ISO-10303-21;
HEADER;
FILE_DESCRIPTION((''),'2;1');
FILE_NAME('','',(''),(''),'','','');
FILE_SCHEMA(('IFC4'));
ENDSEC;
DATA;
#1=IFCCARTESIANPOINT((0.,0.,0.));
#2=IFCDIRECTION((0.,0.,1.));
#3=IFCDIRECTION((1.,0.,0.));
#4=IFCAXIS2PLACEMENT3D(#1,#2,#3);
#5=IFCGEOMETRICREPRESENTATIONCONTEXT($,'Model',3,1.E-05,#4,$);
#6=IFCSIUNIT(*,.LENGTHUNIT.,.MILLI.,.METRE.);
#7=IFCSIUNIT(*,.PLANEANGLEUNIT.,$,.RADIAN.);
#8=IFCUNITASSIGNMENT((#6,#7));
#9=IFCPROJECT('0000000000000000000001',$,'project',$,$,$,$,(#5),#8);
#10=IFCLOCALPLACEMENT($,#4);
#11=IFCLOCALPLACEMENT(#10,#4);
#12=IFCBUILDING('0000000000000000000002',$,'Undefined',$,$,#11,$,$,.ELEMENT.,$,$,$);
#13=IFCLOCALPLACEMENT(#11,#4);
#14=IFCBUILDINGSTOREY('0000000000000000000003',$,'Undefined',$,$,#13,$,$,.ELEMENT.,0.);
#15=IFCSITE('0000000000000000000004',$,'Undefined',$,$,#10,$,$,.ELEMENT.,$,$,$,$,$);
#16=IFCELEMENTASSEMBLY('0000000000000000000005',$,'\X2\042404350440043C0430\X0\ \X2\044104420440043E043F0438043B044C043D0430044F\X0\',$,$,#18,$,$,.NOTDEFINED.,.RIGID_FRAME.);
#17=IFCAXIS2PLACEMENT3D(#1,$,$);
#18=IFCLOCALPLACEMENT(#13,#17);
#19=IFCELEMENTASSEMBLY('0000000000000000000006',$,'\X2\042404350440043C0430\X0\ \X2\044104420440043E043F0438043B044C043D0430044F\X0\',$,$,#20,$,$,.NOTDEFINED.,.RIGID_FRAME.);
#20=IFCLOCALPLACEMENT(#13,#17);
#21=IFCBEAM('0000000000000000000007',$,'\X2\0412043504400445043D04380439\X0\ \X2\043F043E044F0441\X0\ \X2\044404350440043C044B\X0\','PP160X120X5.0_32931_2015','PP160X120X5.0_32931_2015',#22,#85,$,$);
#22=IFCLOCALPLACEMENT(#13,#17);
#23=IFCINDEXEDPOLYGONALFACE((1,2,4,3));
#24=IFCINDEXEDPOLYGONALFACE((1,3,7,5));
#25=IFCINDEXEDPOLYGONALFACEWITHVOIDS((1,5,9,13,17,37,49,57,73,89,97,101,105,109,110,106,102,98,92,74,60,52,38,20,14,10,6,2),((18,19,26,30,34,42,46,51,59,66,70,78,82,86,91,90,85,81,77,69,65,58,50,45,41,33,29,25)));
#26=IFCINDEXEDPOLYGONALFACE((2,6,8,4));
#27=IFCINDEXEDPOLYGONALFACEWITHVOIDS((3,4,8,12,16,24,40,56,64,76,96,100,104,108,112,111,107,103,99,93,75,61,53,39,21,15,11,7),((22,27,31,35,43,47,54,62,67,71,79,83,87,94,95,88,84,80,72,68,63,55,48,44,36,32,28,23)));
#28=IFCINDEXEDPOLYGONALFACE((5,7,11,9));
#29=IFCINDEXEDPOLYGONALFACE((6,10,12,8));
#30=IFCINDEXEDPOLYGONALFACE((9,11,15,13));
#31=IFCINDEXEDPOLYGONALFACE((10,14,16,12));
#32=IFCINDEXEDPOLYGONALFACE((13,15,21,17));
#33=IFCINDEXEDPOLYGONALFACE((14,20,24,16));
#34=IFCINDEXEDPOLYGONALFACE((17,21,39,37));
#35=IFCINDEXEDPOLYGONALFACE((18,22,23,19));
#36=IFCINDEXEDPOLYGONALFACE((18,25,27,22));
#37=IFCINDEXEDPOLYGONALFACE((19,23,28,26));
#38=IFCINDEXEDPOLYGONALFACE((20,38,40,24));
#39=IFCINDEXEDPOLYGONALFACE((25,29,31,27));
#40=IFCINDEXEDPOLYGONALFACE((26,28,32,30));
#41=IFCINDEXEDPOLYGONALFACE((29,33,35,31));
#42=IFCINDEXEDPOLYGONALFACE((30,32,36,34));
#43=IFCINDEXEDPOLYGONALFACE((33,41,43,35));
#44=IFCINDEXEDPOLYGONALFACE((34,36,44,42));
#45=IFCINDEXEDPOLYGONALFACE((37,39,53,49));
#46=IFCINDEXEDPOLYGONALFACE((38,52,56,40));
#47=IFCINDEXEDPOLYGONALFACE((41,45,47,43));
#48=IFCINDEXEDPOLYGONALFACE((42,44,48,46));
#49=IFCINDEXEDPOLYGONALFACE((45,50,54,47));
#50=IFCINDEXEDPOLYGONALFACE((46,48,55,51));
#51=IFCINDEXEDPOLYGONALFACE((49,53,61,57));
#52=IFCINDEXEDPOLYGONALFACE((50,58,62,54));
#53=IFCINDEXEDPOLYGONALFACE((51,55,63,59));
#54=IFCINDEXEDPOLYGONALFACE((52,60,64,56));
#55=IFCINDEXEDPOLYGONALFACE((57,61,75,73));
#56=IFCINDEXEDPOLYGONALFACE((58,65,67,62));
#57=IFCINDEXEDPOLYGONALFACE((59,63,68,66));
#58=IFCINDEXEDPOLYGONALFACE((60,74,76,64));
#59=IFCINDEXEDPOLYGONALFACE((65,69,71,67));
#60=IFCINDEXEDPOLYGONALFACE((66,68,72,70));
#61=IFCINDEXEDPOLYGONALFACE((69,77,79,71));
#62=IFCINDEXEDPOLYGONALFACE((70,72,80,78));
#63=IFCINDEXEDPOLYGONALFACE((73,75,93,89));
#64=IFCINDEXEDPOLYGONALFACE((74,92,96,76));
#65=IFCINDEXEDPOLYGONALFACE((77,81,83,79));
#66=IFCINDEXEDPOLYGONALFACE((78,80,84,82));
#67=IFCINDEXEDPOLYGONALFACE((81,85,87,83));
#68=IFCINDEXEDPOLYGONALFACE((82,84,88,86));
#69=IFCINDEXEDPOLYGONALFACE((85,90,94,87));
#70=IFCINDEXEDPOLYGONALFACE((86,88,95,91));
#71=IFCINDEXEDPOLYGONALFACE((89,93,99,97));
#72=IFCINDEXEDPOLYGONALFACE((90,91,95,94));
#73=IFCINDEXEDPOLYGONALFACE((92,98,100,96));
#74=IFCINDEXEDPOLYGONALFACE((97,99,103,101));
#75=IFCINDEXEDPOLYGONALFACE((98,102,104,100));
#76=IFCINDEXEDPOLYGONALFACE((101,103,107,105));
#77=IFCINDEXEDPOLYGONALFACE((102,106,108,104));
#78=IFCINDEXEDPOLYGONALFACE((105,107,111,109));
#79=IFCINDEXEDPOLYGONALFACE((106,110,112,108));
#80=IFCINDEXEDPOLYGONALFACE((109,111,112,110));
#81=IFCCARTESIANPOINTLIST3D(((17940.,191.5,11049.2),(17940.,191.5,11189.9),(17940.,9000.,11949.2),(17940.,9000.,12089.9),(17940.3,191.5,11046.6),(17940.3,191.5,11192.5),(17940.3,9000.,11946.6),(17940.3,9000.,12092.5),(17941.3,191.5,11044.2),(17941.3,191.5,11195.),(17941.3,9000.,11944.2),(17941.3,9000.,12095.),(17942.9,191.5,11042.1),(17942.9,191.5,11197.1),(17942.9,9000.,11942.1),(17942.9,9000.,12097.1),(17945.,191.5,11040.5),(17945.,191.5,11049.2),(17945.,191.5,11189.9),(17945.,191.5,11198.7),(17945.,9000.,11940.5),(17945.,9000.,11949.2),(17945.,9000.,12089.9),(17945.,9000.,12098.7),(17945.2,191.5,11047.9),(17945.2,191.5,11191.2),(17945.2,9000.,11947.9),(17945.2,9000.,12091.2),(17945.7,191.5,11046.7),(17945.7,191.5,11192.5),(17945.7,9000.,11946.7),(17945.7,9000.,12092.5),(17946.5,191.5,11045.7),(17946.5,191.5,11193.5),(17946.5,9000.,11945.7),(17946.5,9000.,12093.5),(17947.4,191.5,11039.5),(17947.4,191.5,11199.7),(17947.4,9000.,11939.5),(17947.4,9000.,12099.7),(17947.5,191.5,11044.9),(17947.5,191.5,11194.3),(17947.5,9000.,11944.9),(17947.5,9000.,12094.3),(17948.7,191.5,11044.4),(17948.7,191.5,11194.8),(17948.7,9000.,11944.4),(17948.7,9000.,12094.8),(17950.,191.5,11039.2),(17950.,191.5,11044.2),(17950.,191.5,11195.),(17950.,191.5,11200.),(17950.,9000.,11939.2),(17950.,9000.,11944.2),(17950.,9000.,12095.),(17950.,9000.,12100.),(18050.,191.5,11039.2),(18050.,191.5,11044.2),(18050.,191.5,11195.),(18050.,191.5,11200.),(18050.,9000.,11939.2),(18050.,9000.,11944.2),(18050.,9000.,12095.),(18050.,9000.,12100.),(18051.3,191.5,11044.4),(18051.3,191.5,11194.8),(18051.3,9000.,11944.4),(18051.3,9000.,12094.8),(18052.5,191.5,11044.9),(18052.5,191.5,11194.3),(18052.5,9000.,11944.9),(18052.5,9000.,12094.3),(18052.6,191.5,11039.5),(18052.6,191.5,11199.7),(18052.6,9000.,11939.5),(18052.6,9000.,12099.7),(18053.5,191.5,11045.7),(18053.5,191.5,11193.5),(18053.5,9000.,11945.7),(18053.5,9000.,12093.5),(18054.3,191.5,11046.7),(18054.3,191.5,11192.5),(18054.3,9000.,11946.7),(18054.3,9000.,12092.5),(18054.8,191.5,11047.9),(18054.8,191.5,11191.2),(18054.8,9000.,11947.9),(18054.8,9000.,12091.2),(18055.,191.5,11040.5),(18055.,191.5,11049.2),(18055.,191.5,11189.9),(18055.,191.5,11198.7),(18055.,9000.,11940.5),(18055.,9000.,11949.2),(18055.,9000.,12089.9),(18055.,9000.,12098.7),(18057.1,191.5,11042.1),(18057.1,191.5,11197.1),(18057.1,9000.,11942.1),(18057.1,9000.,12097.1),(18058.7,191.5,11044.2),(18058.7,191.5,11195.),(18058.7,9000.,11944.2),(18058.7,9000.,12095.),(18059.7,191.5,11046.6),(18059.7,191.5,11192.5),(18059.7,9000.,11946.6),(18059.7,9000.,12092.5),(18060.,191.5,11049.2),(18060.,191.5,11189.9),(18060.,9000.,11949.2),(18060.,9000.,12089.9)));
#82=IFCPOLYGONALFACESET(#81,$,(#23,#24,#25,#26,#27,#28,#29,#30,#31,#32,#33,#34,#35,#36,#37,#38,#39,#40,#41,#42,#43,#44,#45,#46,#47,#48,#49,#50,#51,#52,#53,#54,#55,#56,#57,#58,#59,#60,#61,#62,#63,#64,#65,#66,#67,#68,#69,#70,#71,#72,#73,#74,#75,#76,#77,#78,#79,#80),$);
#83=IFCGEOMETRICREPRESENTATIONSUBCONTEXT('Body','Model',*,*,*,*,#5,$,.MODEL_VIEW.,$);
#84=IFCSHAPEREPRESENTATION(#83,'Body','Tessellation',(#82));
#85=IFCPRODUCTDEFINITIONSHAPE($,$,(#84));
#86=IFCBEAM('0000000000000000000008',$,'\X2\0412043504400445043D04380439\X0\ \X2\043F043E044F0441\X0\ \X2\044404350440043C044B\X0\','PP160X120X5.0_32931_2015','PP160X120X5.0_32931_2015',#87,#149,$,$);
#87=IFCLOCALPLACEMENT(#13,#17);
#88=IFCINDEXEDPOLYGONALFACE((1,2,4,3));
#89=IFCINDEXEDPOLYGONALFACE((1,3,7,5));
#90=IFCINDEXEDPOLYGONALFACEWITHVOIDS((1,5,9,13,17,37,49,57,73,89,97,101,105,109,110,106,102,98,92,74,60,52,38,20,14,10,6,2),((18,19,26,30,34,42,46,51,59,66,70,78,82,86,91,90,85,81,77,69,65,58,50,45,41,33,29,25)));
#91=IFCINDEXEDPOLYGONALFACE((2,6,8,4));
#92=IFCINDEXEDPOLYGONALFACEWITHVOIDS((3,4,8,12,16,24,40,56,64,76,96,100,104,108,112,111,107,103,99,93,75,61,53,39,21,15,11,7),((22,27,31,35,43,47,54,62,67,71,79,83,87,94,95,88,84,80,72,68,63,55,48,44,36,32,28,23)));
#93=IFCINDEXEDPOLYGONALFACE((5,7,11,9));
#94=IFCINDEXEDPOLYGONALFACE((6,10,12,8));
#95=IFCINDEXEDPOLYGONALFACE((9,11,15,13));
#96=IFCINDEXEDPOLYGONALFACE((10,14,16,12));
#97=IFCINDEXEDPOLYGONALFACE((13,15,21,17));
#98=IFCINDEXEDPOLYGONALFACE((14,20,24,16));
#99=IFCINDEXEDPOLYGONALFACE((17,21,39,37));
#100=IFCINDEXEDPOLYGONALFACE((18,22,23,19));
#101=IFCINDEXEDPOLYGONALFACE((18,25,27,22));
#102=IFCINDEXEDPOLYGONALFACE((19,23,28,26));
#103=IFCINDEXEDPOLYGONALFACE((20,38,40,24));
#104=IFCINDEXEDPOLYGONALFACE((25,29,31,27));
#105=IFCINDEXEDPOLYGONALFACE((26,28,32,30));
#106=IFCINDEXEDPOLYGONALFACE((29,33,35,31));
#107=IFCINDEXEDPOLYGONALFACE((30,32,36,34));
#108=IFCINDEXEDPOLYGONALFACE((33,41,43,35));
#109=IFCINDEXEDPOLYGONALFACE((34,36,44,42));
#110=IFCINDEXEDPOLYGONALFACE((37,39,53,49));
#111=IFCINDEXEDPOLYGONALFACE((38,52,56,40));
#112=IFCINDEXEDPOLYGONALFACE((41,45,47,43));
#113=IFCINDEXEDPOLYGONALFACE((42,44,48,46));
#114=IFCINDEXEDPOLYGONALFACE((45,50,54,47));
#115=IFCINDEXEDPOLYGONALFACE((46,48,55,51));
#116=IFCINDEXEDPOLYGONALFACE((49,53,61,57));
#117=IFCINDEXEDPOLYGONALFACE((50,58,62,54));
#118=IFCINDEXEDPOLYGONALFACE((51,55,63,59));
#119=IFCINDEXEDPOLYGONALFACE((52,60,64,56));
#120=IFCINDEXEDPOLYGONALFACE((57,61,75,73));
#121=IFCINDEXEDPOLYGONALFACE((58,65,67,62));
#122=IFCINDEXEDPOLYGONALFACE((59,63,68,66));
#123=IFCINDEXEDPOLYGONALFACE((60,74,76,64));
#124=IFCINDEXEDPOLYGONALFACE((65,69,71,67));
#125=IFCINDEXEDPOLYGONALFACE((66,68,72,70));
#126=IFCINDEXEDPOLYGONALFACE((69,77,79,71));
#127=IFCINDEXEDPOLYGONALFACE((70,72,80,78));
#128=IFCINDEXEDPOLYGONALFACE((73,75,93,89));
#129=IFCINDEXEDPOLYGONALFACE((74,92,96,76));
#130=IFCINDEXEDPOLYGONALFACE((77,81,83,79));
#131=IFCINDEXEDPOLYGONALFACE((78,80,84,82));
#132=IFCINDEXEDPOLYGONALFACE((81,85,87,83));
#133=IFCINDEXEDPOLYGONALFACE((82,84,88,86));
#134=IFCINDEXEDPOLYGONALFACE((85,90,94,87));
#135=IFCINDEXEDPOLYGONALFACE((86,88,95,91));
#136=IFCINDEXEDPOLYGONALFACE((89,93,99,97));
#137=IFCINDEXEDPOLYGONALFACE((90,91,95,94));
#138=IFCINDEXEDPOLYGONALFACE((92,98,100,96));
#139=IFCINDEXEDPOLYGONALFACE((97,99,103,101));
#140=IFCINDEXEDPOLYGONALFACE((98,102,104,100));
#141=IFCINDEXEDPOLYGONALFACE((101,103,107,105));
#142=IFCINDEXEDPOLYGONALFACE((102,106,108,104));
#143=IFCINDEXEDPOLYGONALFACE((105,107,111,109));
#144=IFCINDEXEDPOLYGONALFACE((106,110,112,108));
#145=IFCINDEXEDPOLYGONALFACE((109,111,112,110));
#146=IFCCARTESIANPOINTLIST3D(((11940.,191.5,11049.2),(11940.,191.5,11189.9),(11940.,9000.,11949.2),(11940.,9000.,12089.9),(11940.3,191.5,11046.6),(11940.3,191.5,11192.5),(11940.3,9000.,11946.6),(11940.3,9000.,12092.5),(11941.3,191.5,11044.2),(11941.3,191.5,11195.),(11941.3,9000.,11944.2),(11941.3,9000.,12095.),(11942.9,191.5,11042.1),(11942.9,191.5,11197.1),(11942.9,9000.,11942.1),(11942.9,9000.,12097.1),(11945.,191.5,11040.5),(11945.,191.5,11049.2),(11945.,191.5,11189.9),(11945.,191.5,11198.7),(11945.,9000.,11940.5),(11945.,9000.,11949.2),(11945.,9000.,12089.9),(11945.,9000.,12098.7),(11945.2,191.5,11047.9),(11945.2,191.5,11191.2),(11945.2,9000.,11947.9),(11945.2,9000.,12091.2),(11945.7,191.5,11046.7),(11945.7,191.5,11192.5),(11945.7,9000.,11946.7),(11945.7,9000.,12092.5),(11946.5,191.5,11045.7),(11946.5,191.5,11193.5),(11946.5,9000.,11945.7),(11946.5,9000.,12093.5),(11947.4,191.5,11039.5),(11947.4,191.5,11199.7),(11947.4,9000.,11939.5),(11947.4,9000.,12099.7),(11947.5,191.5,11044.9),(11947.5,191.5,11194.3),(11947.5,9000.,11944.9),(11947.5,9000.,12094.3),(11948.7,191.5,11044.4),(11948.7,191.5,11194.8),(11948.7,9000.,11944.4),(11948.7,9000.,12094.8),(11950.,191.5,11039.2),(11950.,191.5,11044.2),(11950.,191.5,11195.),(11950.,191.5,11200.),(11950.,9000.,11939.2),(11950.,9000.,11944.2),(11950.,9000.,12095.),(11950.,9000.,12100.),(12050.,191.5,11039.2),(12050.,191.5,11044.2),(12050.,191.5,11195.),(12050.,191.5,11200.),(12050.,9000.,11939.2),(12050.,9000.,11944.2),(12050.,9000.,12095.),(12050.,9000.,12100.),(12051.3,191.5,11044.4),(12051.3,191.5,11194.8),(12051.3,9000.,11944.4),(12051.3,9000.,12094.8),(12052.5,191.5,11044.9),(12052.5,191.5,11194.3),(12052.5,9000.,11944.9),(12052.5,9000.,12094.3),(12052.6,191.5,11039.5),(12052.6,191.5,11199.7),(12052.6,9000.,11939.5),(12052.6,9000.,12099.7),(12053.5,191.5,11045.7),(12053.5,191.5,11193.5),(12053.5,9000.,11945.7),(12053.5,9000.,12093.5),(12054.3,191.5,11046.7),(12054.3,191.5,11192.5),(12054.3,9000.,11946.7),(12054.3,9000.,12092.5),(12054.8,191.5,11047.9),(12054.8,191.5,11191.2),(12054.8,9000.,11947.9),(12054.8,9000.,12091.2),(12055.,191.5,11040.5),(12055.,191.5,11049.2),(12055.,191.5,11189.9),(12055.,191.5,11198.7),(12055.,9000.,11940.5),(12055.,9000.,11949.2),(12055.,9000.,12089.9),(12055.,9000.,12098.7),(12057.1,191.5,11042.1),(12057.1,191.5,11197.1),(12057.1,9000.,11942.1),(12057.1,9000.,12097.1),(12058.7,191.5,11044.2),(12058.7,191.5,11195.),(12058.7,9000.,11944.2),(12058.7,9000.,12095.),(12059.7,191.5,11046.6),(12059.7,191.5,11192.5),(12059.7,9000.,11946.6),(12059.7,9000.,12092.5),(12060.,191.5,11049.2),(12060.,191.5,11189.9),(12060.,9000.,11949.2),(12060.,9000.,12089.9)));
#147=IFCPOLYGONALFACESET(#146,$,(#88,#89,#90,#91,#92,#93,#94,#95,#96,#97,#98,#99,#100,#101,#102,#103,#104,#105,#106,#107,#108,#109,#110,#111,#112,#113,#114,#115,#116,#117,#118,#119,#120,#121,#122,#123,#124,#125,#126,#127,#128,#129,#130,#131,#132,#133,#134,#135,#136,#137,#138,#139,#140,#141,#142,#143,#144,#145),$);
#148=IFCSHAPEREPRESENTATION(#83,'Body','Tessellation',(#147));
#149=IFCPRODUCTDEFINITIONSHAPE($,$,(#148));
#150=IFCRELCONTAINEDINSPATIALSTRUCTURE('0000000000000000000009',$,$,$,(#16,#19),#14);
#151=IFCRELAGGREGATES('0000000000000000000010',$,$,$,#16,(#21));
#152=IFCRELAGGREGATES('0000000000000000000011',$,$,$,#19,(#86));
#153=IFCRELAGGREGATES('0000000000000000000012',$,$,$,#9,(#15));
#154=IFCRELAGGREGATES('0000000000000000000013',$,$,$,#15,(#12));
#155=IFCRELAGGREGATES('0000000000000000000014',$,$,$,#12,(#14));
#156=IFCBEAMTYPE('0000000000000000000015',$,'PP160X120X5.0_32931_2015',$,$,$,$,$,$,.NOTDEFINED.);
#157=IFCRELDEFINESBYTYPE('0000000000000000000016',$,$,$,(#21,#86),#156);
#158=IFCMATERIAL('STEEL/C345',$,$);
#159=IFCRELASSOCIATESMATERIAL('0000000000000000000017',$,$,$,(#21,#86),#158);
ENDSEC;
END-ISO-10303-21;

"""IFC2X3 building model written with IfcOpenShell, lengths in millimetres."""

from ifc_helpers import new_model, si_unit, frame, origin_with_axes, origin_2d_with_axis, place, context, subcontext, project, spatial, hollow_rectangle, extrude, clip, halfspace, material, type_object, element, aggregate, save


model = new_model("IFC2X3")

# Units and contexts
model_context = context("Model", 3, precision=1e-05, world=origin_with_axes())
body_context = subcontext(model_context, "Body", "Model", "MODEL_VIEW")
ifc_project = project(units=[si_unit("LENGTHUNIT", "METRE", prefix="MILLI"), si_unit("PLANEANGLEUNIT", "RADIAN")], contexts=[model_context])

# Site, building, storey
site_placement = place(None, origin_with_axes())
site = spatial("IfcSite", under=ifc_project, at=site_placement, Name="Undefined", CompositionType="ELEMENT")
building_placement = place(site_placement, origin_with_axes())
building = spatial("IfcBuilding", under=site, at=building_placement, Name="Undefined", CompositionType="ELEMENT")
storey_placement = place(building_placement, origin_with_axes())
storey = spatial("IfcBuildingStorey", under=building, at=storey_placement, Name="Undefined", CompositionType="ELEMENT", Elevation=0.0)

# Shared definitions
ifc_material_1 = material(Name="STEEL/C345")

# Element assembly
assembly_1_placement = place(storey_placement, origin_with_axes())
assembly_1 = element("IfcElementAssembly", 1, at=assembly_1_placement, inside=storey, Name="Ферма стропильная", AssemblyPlace="NOTDEFINED", PredefinedType="RIGID_FRAME")

# Element assembly
assembly_2_placement = place(storey_placement, origin_with_axes())
assembly_2 = element("IfcElementAssembly", 2, at=assembly_2_placement, inside=storey, Name="Ферма стропильная", AssemblyPlace="NOTDEFINED", PredefinedType="RIGID_FRAME")

# Beams
beam_type_1 = type_object("IfcBeamType", Name="PP160X120X5.0_32931_2015", PredefinedType="NOTDEFINED")
beam_1_placement = place(assembly_1_placement, frame((18000.0, 199.6, 11120.4), z_axis=(0.0, -0.101645, 0.994821), x_axis=(0.0, 0.994821, 0.101645)))
beam_1 = element("IfcBeam", 3, at=beam_1_placement, type_object=beam_type_1, material=ifc_material_1, Name="Верхний пояс фермы", Description="PP160X120X5.0_32931_2015", ObjectType="PP160X120X5.0_32931_2015", context=body_context, shape_type="Clipping", body=[
    clip(clip(extrude(hollow_rectangle(XDim=120.0, YDim=160.0, WallThickness=5.0, InnerFilletRadius=5.0, OuterFilletRadius=10.0, at=origin_2d_with_axis()), frame((8862.7, 0.0, 0.0), z_axis=(-1.0, 0.0, 0.0), x_axis=(0.0, -1.0, 0.0)), (0.0, 0.0, 1.0), 8887.4), halfspace(frame((8854.4, 0.0, 80.0), z_axis=(0.994821, 0.0, -0.101645), x_axis=(0.0, -1.0, 0.0)), False)), halfspace(frame((0.0, 0.0, 80.0), z_axis=(0.994821, 0.0, -0.101645), x_axis=(0.0, -1.0, 0.0)), True)),
])
aggregate(assembly_1, [beam_1])
beam_2_placement = place(assembly_2_placement, frame((12000.0, 199.6, 11120.4), z_axis=(0.0, -0.101645, 0.994821), x_axis=(0.0, 0.994821, 0.101645)))
beam_2 = element("IfcBeam", 4, at=beam_2_placement, type_object=beam_type_1, material=ifc_material_1, Name="Верхний пояс фермы", Description="PP160X120X5.0_32931_2015", ObjectType="PP160X120X5.0_32931_2015", context=body_context, shape_type="Clipping", body=[
    clip(clip(extrude(hollow_rectangle(XDim=120.0, YDim=160.0, WallThickness=5.0, InnerFilletRadius=5.0, OuterFilletRadius=10.0, at=origin_2d_with_axis()), frame((8862.7, 0.0, 0.0), z_axis=(-1.0, 0.0, 0.0), x_axis=(0.0, -1.0, 0.0)), (0.0, 0.0, 1.0), 8887.4), halfspace(frame((8854.4, 0.0, 80.0), z_axis=(0.994821, 0.0, -0.101645), x_axis=(0.0, -1.0, 0.0)), False)), halfspace(frame((0.0, 0.0, 80.0), z_axis=(0.994821, 0.0, -0.101645), x_axis=(0.0, -1.0, 0.0)), True)),
])
aggregate(assembly_2, [beam_2])

save(model, "model.ifc")
